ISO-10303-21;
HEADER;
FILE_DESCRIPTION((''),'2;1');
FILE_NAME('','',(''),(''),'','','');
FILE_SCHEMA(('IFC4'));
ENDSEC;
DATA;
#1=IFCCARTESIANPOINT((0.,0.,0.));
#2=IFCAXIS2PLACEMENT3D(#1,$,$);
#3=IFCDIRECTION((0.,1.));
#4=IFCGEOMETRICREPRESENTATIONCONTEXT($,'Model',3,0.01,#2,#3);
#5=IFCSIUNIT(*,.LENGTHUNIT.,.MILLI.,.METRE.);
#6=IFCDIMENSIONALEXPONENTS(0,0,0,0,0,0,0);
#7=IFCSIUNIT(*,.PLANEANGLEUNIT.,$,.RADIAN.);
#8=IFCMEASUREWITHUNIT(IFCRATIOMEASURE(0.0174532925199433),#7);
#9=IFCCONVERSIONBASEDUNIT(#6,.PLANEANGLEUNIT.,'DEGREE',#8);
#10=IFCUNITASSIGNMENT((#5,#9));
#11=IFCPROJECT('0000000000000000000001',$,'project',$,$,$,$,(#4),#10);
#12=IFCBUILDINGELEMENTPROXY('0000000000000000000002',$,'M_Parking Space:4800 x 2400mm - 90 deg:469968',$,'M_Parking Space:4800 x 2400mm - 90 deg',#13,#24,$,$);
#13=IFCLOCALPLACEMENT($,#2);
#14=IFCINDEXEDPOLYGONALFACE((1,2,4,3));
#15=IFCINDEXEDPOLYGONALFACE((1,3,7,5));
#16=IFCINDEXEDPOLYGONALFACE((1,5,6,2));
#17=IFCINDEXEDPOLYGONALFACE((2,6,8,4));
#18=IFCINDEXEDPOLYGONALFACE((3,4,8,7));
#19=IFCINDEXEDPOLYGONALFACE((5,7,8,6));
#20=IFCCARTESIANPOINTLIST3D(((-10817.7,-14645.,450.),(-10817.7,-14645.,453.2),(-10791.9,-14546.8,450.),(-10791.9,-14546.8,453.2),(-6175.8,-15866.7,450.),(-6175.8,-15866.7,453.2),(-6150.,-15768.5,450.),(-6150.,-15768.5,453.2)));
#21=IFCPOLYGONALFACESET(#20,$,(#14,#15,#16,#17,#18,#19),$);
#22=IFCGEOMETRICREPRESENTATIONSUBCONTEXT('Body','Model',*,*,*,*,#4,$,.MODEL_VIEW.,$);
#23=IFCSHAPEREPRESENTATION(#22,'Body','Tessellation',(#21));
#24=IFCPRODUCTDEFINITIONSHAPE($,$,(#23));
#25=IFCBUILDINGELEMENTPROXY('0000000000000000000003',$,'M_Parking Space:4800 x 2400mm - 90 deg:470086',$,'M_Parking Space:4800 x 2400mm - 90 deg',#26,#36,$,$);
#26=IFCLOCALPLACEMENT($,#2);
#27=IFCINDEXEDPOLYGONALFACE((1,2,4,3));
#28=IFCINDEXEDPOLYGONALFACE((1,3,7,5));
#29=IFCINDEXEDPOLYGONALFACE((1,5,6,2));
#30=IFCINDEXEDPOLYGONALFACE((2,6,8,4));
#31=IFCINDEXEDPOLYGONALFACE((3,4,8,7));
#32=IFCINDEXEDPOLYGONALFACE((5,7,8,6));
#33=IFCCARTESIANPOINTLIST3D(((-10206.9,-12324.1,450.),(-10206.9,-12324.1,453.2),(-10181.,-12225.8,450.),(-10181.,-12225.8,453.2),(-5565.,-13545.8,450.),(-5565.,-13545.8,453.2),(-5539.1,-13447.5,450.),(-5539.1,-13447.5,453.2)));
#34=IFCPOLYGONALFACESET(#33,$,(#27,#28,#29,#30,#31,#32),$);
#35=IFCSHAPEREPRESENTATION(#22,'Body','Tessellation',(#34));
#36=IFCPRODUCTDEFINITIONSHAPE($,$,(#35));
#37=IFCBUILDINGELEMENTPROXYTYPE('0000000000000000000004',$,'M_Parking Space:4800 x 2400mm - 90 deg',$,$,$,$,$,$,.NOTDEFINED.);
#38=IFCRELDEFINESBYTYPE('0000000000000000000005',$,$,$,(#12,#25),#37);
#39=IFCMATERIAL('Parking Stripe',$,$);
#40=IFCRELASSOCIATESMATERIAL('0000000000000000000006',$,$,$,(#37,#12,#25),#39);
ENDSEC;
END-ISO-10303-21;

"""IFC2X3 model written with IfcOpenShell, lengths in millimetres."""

from ifc_helpers import new_model, entity, si_unit, converted_unit, direction, frame, origin, origin_2d_with_axis, place, context, subcontext, project, rectangle, extrude, source, transform, mapped, material, type_object, type_shapes, element, save


model = new_model("IFC2X3")

# Units and contexts
model_context = context("Model", 3, precision=0.01, world=origin(), true_north=direction((0.0, 1.0)))
body_context = subcontext(model_context, "Body", "Model", "MODEL_VIEW")
ifc_project = project(units=[si_unit("LENGTHUNIT", "METRE", prefix="MILLI"), converted_unit("PLANEANGLEUNIT", "DEGREE", entity("IfcRatioMeasure", 0.0174532925199433), si_unit("PLANEANGLEUNIT", "RADIAN"), dimensions=[0, 0, 0, 0, 0, 0, 0])], contexts=[model_context])

# Building element proxies
ifc_material = material(Name="Parking Stripe")
building_element_proxy_type = type_object("IfcBuildingElementProxyType", Name="M_Parking Space:4800 x 2400mm - 90 deg", PredefinedType="NOTDEFINED", material=ifc_material)
shared_shape = source(origin(), body_context, "Body", "SweptSolid", [
    extrude(rectangle(XDim=101.6, YDim=4800.0, at=origin_2d_with_axis()), frame((0.0, 2400.0, 0.0)), (0.0, 0.0, 1.0), 3.2),
])
type_shapes(building_element_proxy_type, [shared_shape])
placement_1 = place(None, origin())
placement_2 = place(placement_1, origin())
placement_3 = place(placement_2, frame((0.0, 0.0, 450.0)))
for number, where, z_axis, x_axis, name in (
    (1, (-6162.9, -15817.6, 0.0), (0.0, 0.0, 1.0), (0.25452, 0.967067, 0.0), "M_Parking Space:4800 x 2400mm - 90 deg:469968"),
    (2, (-5552.0, -13496.6, 0.0), (0.0, 0.0, 1.0), (0.25452, 0.967067, 0.0), "M_Parking Space:4800 x 2400mm - 90 deg:470086"),
):
    element("IfcBuildingElementProxy", number, at=place(placement_3, frame(where, z_axis=z_axis, x_axis=x_axis)), type_object=building_element_proxy_type, material=ifc_material, Name=name, ObjectType="M_Parking Space:4800 x 2400mm - 90 deg", context=body_context, shape_type="MappedRepresentation", body=[
        mapped(shared_shape, transform((0.0, 0.0, 0.0), scale=1.0)),
    ])

save(model, "model.ifc")
